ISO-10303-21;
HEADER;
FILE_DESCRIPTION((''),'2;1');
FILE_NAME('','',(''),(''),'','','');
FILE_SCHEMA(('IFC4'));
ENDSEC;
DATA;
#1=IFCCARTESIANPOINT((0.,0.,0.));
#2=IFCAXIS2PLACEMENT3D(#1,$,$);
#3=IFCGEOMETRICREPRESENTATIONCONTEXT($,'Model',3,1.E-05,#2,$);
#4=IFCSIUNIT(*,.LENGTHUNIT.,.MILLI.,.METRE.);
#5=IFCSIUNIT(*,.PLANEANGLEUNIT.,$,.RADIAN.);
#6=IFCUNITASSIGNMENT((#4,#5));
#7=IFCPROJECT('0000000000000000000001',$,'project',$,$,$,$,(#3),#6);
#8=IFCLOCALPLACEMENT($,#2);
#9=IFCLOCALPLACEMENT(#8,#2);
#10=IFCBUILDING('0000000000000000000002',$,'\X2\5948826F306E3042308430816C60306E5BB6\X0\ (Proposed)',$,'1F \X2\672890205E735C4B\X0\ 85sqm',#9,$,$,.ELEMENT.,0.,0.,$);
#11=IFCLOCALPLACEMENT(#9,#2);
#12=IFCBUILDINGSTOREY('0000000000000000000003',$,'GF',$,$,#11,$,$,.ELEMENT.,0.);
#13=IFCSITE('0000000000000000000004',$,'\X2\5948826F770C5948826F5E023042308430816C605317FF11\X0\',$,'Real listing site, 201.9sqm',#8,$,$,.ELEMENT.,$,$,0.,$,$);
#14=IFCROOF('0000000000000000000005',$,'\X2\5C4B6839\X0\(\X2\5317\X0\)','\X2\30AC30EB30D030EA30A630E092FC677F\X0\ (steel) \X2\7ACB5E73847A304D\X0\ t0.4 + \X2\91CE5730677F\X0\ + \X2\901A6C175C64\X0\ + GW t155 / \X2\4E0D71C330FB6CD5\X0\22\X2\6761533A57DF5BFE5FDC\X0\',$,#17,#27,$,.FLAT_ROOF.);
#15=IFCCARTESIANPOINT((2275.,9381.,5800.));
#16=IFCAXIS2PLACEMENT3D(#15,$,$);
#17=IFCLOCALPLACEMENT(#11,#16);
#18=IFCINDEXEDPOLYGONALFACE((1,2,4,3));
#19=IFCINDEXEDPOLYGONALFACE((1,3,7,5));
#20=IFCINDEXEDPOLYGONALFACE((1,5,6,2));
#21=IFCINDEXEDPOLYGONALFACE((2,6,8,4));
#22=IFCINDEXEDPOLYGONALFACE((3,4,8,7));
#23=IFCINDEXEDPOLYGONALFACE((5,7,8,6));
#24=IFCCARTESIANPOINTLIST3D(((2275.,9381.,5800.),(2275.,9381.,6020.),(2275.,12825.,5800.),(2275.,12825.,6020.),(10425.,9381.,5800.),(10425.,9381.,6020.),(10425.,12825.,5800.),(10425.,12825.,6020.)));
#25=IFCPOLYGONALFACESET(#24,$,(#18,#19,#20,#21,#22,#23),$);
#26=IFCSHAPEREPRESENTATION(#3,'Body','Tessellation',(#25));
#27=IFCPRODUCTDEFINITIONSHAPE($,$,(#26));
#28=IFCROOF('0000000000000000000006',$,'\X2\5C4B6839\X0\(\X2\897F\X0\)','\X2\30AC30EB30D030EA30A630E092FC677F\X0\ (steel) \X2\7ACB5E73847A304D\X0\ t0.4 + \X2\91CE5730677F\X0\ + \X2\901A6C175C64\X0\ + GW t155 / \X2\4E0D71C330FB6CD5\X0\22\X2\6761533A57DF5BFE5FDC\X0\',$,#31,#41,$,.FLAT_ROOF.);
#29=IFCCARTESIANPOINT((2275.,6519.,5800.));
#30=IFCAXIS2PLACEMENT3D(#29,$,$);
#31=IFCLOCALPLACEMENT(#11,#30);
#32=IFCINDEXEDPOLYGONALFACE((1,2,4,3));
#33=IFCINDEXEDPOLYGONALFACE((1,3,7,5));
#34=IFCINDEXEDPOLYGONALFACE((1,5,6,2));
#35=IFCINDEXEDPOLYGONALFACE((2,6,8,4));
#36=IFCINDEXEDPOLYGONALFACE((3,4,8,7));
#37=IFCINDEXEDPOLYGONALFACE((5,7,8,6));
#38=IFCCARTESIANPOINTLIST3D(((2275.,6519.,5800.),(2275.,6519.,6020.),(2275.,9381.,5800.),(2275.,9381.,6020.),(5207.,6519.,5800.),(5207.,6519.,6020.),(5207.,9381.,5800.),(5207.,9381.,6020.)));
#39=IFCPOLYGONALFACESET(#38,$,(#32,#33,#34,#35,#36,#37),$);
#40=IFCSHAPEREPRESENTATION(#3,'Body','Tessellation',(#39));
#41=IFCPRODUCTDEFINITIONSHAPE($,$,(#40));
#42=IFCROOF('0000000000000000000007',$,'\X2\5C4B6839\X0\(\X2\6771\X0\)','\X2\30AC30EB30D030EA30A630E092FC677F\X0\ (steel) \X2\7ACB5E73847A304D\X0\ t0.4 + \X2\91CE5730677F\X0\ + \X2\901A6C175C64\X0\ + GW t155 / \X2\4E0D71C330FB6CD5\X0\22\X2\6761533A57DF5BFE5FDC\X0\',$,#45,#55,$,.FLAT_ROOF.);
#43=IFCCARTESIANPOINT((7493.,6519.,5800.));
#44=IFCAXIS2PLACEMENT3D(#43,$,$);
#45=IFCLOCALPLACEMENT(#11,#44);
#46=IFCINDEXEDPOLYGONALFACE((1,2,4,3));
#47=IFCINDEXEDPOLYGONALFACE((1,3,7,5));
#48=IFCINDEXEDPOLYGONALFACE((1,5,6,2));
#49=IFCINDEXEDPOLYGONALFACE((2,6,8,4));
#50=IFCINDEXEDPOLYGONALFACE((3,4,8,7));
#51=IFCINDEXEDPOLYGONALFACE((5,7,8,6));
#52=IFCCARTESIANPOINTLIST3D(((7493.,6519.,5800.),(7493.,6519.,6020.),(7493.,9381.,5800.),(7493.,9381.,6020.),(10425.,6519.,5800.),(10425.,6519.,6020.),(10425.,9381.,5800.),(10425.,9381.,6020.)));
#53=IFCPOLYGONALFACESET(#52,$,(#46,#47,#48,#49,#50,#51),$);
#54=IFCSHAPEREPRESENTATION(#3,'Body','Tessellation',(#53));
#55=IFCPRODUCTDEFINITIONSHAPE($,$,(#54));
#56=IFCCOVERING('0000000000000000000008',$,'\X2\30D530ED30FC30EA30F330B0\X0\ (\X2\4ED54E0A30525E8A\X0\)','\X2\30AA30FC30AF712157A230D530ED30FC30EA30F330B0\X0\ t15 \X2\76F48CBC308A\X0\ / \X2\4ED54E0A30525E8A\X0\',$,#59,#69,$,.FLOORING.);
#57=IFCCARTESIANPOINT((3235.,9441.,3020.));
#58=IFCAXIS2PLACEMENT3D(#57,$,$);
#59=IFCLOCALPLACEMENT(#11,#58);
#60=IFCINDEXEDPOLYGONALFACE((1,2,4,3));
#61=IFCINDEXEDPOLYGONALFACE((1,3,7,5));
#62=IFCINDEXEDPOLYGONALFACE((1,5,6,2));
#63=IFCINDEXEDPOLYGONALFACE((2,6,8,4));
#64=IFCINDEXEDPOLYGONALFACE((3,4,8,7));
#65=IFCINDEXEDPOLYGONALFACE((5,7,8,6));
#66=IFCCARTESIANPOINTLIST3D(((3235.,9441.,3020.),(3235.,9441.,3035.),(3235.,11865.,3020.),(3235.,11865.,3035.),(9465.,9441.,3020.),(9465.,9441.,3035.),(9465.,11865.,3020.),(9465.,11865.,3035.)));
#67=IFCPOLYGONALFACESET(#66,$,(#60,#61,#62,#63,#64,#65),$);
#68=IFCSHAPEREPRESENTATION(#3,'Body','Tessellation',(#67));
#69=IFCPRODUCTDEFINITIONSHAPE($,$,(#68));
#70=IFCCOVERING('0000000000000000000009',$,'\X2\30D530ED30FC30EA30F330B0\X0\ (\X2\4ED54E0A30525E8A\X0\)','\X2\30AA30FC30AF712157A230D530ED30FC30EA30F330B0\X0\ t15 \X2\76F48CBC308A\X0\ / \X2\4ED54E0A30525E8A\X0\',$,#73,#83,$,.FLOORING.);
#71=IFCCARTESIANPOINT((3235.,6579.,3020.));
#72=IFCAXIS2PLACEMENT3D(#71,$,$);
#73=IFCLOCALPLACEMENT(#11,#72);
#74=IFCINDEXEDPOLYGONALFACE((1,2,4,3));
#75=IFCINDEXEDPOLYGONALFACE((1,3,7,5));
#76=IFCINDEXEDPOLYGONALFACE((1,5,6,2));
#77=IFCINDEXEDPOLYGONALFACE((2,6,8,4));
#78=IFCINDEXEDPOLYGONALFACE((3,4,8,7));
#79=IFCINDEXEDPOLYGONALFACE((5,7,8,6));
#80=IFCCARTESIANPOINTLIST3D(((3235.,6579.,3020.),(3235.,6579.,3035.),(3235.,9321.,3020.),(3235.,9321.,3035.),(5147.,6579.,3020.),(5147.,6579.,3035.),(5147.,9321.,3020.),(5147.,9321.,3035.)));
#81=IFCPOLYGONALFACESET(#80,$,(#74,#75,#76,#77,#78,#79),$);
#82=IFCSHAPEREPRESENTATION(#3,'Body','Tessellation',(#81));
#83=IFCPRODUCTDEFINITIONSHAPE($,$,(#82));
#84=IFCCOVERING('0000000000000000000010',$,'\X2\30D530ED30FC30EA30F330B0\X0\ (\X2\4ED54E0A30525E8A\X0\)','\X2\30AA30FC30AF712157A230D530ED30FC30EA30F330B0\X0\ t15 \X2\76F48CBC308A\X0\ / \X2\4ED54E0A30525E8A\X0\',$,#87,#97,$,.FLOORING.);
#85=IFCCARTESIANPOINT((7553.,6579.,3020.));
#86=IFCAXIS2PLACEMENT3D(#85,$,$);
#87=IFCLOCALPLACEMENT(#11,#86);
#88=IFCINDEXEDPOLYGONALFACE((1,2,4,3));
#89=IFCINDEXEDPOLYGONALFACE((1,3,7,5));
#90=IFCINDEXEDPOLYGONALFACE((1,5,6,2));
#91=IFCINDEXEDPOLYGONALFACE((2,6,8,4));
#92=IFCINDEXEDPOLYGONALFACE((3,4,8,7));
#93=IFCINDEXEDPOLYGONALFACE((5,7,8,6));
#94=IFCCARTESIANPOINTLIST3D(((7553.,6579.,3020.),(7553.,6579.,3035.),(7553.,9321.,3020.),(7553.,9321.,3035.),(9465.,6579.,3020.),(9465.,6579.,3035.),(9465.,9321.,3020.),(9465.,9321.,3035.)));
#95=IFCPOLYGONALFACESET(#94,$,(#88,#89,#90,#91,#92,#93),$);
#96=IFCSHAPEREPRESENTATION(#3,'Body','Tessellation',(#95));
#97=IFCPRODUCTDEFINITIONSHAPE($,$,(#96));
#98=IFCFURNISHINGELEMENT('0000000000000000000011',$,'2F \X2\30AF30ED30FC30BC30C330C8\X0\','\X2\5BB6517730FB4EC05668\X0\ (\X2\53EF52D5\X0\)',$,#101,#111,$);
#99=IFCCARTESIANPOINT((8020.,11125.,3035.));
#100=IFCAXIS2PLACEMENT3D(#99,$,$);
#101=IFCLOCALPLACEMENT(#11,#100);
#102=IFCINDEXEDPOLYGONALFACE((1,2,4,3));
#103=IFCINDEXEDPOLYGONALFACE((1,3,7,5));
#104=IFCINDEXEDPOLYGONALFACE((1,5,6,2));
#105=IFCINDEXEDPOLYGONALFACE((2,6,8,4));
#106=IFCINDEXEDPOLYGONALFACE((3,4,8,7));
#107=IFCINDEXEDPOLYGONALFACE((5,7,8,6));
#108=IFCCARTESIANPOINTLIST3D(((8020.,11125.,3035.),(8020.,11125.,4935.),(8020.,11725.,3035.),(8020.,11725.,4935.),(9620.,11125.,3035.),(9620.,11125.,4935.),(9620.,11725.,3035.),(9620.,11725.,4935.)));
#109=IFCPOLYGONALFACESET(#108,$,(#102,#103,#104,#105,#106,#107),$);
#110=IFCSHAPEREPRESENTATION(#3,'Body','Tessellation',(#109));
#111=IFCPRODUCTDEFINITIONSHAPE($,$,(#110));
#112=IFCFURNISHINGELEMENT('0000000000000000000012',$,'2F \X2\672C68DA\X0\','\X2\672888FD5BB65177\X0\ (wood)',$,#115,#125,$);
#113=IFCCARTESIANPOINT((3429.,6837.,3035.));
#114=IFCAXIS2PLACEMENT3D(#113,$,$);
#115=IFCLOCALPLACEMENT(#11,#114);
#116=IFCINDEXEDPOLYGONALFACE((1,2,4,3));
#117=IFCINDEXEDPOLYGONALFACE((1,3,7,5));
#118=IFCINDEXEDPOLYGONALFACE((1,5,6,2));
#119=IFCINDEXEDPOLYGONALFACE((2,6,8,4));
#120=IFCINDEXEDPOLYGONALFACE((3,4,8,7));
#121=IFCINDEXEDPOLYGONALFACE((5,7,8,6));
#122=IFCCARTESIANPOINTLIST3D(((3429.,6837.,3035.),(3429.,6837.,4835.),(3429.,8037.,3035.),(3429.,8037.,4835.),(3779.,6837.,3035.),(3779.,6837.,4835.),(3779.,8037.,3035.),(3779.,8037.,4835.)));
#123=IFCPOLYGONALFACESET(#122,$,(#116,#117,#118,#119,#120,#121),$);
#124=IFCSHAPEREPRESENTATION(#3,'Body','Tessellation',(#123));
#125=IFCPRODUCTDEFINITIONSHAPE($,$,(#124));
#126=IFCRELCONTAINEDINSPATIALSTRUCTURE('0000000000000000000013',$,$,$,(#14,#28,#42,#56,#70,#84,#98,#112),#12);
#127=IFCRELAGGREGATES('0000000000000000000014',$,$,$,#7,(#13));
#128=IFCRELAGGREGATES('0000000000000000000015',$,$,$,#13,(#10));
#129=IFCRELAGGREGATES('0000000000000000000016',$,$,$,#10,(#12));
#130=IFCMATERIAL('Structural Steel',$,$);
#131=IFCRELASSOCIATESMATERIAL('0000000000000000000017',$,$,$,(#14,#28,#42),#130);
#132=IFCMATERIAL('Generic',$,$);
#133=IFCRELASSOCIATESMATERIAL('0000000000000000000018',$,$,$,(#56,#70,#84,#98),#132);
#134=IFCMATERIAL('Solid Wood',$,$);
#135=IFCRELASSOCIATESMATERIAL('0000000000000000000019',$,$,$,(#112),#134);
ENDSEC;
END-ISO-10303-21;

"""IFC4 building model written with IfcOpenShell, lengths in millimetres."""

from ifc_helpers import new_model, si_unit, frame, frame_2d, origin, place, context, project, spatial, rectangle, extrude, material, element, save


model = new_model("IFC4")

# Units and contexts
model_context = context("Model", 3, precision=1e-05, world=origin())
ifc_project = project(units=[si_unit("LENGTHUNIT", "METRE", prefix="MILLI"), si_unit("PLANEANGLEUNIT", "RADIAN")], contexts=[model_context])

# Site, building, storey
site_placement = place(None, origin())
site = spatial("IfcSite", under=ifc_project, at=site_placement, Name="奈良県奈良市あやめ池北１", ObjectType="Real listing site, 201.9sqm", CompositionType="ELEMENT", RefElevation=0.0)
building_placement = place(site_placement, origin())
building = spatial("IfcBuilding", under=site, at=building_placement, Name="奈良のあやめ池の家 (Proposed)", ObjectType="1F 木造平屋 85sqm", CompositionType="ELEMENT", ElevationOfRefHeight=0.0, ElevationOfTerrain=0.0)
storey_placement = place(building_placement, origin())
storey = spatial("IfcBuildingStorey", under=building, at=storey_placement, Name="GF", CompositionType="ELEMENT", Elevation=0.0)

# Shared definitions
ifc_material_1 = material(Name="Solid Wood")

# Shared definitions
ifc_material_2 = material(Name="Generic")

# Roofs
ifc_material_3 = material(Name="Structural Steel")
for number, where, name in (
    (1, (2275.0, 9381.0, 5800.0), "屋根(北)"),
):
    element("IfcRoof", number, at=place(storey_placement, frame(where)), inside=storey, material=ifc_material_3, Name=name, Description="ガルバリウム鋼板 (steel) 立平葺き t0.4 + 野地板 + 通気層 + GW t155 / 不燃・法22条区域対応", PredefinedType="FLAT_ROOF", context=model_context, shape_type="SweptSolid", body=[
        extrude(rectangle(XDim=8150.0, YDim=3444.0, at=frame_2d((4075.0, 1722.0))), frame((2275.0, 9381.0, 5800.0)), (0.0, 0.0, 1.0), 220.0),
    ])
roof_1_placement = place(storey_placement, frame((2275.0, 6519.0, 5800.0)))
element("IfcRoof", 2, at=roof_1_placement, inside=storey, material=ifc_material_3, Name="屋根(西)", Description="ガルバリウム鋼板 (steel) 立平葺き t0.4 + 野地板 + 通気層 + GW t155 / 不燃・法22条区域対応", PredefinedType="FLAT_ROOF", context=model_context, shape_type="SweptSolid", body=[
    extrude(rectangle(XDim=2932.0, YDim=2862.0, at=frame_2d((1466.0, 1431.0))), frame((2275.0, 6519.0, 5800.0)), (0.0, 0.0, 1.0), 220.0),
])
roof_2_placement = place(storey_placement, frame((7493.0, 6519.0, 5800.0)))
element("IfcRoof", 3, at=roof_2_placement, inside=storey, material=ifc_material_3, Name="屋根(東)", Description="ガルバリウム鋼板 (steel) 立平葺き t0.4 + 野地板 + 通気層 + GW t155 / 不燃・法22条区域対応", PredefinedType="FLAT_ROOF", context=model_context, shape_type="SweptSolid", body=[
    extrude(rectangle(XDim=2932.0, YDim=2862.0, at=frame_2d((1466.0, 1431.0))), frame((7493.0, 6519.0, 5800.0)), (0.0, 0.0, 1.0), 220.0),
])

# Coverings
covering_1_placement = place(storey_placement, frame((3235.0, 9441.0, 3020.0)))
element("IfcCovering", 4, at=covering_1_placement, inside=storey, material=ifc_material_2, Name="フローリング (仕上げ床)", Description="オーク無垢フローリング t15 直貼り / 仕上げ床", PredefinedType="FLOORING", context=model_context, shape_type="SweptSolid", body=[
    extrude(rectangle(XDim=6230.0, YDim=2424.0, at=frame_2d((3115.0, 1212.0))), frame((3235.0, 9441.0, 3020.0)), (0.0, 0.0, 1.0), 15.0),
])
covering_2_placement = place(storey_placement, frame((3235.0, 6579.0, 3020.0)))
element("IfcCovering", 5, at=covering_2_placement, inside=storey, material=ifc_material_2, Name="フローリング (仕上げ床)", Description="オーク無垢フローリング t15 直貼り / 仕上げ床", PredefinedType="FLOORING", context=model_context, shape_type="SweptSolid", body=[
    extrude(rectangle(XDim=1912.0, YDim=2742.0, at=frame_2d((956.0, 1371.0))), frame((3235.0, 6579.0, 3020.0)), (0.0, 0.0, 1.0), 15.0),
])
covering_3_placement = place(storey_placement, frame((7553.0, 6579.0, 3020.0)))
element("IfcCovering", 6, at=covering_3_placement, inside=storey, material=ifc_material_2, Name="フローリング (仕上げ床)", Description="オーク無垢フローリング t15 直貼り / 仕上げ床", PredefinedType="FLOORING", context=model_context, shape_type="SweptSolid", body=[
    extrude(rectangle(XDim=1912.0, YDim=2742.0, at=frame_2d((956.0, 1371.0))), frame((7553.0, 6579.0, 3020.0)), (0.0, 0.0, 1.0), 15.0),
])

# Furnishing elements
furnishing_1_placement = place(storey_placement, frame((8020.0, 11125.0, 3035.0)))
element("IfcFurnishingElement", 7, at=furnishing_1_placement, inside=storey, material=ifc_material_2, Name="2F クローゼット", Description="家具・什器 (可動)", context=model_context, shape_type="SweptSolid", body=[
    extrude(rectangle(XDim=1600.0, YDim=600.0, at=frame_2d((800.0, 300.0))), frame((8020.0, 11125.0, 3035.0)), (0.0, 0.0, 1.0), 1900.0),
])
furnishing_2_placement = place(storey_placement, frame((3429.0, 6837.0, 3035.0)))
element("IfcFurnishingElement", 8, at=furnishing_2_placement, inside=storey, material=ifc_material_1, Name="2F 本棚", Description="木製家具 (wood)", context=model_context, shape_type="SweptSolid", body=[
    extrude(rectangle(XDim=350.0, YDim=1200.0, at=frame_2d((175.0, 600.0))), frame((3429.0, 6837.0, 3035.0)), (0.0, 0.0, 1.0), 1800.0),
])

save(model, "model.ifc")
